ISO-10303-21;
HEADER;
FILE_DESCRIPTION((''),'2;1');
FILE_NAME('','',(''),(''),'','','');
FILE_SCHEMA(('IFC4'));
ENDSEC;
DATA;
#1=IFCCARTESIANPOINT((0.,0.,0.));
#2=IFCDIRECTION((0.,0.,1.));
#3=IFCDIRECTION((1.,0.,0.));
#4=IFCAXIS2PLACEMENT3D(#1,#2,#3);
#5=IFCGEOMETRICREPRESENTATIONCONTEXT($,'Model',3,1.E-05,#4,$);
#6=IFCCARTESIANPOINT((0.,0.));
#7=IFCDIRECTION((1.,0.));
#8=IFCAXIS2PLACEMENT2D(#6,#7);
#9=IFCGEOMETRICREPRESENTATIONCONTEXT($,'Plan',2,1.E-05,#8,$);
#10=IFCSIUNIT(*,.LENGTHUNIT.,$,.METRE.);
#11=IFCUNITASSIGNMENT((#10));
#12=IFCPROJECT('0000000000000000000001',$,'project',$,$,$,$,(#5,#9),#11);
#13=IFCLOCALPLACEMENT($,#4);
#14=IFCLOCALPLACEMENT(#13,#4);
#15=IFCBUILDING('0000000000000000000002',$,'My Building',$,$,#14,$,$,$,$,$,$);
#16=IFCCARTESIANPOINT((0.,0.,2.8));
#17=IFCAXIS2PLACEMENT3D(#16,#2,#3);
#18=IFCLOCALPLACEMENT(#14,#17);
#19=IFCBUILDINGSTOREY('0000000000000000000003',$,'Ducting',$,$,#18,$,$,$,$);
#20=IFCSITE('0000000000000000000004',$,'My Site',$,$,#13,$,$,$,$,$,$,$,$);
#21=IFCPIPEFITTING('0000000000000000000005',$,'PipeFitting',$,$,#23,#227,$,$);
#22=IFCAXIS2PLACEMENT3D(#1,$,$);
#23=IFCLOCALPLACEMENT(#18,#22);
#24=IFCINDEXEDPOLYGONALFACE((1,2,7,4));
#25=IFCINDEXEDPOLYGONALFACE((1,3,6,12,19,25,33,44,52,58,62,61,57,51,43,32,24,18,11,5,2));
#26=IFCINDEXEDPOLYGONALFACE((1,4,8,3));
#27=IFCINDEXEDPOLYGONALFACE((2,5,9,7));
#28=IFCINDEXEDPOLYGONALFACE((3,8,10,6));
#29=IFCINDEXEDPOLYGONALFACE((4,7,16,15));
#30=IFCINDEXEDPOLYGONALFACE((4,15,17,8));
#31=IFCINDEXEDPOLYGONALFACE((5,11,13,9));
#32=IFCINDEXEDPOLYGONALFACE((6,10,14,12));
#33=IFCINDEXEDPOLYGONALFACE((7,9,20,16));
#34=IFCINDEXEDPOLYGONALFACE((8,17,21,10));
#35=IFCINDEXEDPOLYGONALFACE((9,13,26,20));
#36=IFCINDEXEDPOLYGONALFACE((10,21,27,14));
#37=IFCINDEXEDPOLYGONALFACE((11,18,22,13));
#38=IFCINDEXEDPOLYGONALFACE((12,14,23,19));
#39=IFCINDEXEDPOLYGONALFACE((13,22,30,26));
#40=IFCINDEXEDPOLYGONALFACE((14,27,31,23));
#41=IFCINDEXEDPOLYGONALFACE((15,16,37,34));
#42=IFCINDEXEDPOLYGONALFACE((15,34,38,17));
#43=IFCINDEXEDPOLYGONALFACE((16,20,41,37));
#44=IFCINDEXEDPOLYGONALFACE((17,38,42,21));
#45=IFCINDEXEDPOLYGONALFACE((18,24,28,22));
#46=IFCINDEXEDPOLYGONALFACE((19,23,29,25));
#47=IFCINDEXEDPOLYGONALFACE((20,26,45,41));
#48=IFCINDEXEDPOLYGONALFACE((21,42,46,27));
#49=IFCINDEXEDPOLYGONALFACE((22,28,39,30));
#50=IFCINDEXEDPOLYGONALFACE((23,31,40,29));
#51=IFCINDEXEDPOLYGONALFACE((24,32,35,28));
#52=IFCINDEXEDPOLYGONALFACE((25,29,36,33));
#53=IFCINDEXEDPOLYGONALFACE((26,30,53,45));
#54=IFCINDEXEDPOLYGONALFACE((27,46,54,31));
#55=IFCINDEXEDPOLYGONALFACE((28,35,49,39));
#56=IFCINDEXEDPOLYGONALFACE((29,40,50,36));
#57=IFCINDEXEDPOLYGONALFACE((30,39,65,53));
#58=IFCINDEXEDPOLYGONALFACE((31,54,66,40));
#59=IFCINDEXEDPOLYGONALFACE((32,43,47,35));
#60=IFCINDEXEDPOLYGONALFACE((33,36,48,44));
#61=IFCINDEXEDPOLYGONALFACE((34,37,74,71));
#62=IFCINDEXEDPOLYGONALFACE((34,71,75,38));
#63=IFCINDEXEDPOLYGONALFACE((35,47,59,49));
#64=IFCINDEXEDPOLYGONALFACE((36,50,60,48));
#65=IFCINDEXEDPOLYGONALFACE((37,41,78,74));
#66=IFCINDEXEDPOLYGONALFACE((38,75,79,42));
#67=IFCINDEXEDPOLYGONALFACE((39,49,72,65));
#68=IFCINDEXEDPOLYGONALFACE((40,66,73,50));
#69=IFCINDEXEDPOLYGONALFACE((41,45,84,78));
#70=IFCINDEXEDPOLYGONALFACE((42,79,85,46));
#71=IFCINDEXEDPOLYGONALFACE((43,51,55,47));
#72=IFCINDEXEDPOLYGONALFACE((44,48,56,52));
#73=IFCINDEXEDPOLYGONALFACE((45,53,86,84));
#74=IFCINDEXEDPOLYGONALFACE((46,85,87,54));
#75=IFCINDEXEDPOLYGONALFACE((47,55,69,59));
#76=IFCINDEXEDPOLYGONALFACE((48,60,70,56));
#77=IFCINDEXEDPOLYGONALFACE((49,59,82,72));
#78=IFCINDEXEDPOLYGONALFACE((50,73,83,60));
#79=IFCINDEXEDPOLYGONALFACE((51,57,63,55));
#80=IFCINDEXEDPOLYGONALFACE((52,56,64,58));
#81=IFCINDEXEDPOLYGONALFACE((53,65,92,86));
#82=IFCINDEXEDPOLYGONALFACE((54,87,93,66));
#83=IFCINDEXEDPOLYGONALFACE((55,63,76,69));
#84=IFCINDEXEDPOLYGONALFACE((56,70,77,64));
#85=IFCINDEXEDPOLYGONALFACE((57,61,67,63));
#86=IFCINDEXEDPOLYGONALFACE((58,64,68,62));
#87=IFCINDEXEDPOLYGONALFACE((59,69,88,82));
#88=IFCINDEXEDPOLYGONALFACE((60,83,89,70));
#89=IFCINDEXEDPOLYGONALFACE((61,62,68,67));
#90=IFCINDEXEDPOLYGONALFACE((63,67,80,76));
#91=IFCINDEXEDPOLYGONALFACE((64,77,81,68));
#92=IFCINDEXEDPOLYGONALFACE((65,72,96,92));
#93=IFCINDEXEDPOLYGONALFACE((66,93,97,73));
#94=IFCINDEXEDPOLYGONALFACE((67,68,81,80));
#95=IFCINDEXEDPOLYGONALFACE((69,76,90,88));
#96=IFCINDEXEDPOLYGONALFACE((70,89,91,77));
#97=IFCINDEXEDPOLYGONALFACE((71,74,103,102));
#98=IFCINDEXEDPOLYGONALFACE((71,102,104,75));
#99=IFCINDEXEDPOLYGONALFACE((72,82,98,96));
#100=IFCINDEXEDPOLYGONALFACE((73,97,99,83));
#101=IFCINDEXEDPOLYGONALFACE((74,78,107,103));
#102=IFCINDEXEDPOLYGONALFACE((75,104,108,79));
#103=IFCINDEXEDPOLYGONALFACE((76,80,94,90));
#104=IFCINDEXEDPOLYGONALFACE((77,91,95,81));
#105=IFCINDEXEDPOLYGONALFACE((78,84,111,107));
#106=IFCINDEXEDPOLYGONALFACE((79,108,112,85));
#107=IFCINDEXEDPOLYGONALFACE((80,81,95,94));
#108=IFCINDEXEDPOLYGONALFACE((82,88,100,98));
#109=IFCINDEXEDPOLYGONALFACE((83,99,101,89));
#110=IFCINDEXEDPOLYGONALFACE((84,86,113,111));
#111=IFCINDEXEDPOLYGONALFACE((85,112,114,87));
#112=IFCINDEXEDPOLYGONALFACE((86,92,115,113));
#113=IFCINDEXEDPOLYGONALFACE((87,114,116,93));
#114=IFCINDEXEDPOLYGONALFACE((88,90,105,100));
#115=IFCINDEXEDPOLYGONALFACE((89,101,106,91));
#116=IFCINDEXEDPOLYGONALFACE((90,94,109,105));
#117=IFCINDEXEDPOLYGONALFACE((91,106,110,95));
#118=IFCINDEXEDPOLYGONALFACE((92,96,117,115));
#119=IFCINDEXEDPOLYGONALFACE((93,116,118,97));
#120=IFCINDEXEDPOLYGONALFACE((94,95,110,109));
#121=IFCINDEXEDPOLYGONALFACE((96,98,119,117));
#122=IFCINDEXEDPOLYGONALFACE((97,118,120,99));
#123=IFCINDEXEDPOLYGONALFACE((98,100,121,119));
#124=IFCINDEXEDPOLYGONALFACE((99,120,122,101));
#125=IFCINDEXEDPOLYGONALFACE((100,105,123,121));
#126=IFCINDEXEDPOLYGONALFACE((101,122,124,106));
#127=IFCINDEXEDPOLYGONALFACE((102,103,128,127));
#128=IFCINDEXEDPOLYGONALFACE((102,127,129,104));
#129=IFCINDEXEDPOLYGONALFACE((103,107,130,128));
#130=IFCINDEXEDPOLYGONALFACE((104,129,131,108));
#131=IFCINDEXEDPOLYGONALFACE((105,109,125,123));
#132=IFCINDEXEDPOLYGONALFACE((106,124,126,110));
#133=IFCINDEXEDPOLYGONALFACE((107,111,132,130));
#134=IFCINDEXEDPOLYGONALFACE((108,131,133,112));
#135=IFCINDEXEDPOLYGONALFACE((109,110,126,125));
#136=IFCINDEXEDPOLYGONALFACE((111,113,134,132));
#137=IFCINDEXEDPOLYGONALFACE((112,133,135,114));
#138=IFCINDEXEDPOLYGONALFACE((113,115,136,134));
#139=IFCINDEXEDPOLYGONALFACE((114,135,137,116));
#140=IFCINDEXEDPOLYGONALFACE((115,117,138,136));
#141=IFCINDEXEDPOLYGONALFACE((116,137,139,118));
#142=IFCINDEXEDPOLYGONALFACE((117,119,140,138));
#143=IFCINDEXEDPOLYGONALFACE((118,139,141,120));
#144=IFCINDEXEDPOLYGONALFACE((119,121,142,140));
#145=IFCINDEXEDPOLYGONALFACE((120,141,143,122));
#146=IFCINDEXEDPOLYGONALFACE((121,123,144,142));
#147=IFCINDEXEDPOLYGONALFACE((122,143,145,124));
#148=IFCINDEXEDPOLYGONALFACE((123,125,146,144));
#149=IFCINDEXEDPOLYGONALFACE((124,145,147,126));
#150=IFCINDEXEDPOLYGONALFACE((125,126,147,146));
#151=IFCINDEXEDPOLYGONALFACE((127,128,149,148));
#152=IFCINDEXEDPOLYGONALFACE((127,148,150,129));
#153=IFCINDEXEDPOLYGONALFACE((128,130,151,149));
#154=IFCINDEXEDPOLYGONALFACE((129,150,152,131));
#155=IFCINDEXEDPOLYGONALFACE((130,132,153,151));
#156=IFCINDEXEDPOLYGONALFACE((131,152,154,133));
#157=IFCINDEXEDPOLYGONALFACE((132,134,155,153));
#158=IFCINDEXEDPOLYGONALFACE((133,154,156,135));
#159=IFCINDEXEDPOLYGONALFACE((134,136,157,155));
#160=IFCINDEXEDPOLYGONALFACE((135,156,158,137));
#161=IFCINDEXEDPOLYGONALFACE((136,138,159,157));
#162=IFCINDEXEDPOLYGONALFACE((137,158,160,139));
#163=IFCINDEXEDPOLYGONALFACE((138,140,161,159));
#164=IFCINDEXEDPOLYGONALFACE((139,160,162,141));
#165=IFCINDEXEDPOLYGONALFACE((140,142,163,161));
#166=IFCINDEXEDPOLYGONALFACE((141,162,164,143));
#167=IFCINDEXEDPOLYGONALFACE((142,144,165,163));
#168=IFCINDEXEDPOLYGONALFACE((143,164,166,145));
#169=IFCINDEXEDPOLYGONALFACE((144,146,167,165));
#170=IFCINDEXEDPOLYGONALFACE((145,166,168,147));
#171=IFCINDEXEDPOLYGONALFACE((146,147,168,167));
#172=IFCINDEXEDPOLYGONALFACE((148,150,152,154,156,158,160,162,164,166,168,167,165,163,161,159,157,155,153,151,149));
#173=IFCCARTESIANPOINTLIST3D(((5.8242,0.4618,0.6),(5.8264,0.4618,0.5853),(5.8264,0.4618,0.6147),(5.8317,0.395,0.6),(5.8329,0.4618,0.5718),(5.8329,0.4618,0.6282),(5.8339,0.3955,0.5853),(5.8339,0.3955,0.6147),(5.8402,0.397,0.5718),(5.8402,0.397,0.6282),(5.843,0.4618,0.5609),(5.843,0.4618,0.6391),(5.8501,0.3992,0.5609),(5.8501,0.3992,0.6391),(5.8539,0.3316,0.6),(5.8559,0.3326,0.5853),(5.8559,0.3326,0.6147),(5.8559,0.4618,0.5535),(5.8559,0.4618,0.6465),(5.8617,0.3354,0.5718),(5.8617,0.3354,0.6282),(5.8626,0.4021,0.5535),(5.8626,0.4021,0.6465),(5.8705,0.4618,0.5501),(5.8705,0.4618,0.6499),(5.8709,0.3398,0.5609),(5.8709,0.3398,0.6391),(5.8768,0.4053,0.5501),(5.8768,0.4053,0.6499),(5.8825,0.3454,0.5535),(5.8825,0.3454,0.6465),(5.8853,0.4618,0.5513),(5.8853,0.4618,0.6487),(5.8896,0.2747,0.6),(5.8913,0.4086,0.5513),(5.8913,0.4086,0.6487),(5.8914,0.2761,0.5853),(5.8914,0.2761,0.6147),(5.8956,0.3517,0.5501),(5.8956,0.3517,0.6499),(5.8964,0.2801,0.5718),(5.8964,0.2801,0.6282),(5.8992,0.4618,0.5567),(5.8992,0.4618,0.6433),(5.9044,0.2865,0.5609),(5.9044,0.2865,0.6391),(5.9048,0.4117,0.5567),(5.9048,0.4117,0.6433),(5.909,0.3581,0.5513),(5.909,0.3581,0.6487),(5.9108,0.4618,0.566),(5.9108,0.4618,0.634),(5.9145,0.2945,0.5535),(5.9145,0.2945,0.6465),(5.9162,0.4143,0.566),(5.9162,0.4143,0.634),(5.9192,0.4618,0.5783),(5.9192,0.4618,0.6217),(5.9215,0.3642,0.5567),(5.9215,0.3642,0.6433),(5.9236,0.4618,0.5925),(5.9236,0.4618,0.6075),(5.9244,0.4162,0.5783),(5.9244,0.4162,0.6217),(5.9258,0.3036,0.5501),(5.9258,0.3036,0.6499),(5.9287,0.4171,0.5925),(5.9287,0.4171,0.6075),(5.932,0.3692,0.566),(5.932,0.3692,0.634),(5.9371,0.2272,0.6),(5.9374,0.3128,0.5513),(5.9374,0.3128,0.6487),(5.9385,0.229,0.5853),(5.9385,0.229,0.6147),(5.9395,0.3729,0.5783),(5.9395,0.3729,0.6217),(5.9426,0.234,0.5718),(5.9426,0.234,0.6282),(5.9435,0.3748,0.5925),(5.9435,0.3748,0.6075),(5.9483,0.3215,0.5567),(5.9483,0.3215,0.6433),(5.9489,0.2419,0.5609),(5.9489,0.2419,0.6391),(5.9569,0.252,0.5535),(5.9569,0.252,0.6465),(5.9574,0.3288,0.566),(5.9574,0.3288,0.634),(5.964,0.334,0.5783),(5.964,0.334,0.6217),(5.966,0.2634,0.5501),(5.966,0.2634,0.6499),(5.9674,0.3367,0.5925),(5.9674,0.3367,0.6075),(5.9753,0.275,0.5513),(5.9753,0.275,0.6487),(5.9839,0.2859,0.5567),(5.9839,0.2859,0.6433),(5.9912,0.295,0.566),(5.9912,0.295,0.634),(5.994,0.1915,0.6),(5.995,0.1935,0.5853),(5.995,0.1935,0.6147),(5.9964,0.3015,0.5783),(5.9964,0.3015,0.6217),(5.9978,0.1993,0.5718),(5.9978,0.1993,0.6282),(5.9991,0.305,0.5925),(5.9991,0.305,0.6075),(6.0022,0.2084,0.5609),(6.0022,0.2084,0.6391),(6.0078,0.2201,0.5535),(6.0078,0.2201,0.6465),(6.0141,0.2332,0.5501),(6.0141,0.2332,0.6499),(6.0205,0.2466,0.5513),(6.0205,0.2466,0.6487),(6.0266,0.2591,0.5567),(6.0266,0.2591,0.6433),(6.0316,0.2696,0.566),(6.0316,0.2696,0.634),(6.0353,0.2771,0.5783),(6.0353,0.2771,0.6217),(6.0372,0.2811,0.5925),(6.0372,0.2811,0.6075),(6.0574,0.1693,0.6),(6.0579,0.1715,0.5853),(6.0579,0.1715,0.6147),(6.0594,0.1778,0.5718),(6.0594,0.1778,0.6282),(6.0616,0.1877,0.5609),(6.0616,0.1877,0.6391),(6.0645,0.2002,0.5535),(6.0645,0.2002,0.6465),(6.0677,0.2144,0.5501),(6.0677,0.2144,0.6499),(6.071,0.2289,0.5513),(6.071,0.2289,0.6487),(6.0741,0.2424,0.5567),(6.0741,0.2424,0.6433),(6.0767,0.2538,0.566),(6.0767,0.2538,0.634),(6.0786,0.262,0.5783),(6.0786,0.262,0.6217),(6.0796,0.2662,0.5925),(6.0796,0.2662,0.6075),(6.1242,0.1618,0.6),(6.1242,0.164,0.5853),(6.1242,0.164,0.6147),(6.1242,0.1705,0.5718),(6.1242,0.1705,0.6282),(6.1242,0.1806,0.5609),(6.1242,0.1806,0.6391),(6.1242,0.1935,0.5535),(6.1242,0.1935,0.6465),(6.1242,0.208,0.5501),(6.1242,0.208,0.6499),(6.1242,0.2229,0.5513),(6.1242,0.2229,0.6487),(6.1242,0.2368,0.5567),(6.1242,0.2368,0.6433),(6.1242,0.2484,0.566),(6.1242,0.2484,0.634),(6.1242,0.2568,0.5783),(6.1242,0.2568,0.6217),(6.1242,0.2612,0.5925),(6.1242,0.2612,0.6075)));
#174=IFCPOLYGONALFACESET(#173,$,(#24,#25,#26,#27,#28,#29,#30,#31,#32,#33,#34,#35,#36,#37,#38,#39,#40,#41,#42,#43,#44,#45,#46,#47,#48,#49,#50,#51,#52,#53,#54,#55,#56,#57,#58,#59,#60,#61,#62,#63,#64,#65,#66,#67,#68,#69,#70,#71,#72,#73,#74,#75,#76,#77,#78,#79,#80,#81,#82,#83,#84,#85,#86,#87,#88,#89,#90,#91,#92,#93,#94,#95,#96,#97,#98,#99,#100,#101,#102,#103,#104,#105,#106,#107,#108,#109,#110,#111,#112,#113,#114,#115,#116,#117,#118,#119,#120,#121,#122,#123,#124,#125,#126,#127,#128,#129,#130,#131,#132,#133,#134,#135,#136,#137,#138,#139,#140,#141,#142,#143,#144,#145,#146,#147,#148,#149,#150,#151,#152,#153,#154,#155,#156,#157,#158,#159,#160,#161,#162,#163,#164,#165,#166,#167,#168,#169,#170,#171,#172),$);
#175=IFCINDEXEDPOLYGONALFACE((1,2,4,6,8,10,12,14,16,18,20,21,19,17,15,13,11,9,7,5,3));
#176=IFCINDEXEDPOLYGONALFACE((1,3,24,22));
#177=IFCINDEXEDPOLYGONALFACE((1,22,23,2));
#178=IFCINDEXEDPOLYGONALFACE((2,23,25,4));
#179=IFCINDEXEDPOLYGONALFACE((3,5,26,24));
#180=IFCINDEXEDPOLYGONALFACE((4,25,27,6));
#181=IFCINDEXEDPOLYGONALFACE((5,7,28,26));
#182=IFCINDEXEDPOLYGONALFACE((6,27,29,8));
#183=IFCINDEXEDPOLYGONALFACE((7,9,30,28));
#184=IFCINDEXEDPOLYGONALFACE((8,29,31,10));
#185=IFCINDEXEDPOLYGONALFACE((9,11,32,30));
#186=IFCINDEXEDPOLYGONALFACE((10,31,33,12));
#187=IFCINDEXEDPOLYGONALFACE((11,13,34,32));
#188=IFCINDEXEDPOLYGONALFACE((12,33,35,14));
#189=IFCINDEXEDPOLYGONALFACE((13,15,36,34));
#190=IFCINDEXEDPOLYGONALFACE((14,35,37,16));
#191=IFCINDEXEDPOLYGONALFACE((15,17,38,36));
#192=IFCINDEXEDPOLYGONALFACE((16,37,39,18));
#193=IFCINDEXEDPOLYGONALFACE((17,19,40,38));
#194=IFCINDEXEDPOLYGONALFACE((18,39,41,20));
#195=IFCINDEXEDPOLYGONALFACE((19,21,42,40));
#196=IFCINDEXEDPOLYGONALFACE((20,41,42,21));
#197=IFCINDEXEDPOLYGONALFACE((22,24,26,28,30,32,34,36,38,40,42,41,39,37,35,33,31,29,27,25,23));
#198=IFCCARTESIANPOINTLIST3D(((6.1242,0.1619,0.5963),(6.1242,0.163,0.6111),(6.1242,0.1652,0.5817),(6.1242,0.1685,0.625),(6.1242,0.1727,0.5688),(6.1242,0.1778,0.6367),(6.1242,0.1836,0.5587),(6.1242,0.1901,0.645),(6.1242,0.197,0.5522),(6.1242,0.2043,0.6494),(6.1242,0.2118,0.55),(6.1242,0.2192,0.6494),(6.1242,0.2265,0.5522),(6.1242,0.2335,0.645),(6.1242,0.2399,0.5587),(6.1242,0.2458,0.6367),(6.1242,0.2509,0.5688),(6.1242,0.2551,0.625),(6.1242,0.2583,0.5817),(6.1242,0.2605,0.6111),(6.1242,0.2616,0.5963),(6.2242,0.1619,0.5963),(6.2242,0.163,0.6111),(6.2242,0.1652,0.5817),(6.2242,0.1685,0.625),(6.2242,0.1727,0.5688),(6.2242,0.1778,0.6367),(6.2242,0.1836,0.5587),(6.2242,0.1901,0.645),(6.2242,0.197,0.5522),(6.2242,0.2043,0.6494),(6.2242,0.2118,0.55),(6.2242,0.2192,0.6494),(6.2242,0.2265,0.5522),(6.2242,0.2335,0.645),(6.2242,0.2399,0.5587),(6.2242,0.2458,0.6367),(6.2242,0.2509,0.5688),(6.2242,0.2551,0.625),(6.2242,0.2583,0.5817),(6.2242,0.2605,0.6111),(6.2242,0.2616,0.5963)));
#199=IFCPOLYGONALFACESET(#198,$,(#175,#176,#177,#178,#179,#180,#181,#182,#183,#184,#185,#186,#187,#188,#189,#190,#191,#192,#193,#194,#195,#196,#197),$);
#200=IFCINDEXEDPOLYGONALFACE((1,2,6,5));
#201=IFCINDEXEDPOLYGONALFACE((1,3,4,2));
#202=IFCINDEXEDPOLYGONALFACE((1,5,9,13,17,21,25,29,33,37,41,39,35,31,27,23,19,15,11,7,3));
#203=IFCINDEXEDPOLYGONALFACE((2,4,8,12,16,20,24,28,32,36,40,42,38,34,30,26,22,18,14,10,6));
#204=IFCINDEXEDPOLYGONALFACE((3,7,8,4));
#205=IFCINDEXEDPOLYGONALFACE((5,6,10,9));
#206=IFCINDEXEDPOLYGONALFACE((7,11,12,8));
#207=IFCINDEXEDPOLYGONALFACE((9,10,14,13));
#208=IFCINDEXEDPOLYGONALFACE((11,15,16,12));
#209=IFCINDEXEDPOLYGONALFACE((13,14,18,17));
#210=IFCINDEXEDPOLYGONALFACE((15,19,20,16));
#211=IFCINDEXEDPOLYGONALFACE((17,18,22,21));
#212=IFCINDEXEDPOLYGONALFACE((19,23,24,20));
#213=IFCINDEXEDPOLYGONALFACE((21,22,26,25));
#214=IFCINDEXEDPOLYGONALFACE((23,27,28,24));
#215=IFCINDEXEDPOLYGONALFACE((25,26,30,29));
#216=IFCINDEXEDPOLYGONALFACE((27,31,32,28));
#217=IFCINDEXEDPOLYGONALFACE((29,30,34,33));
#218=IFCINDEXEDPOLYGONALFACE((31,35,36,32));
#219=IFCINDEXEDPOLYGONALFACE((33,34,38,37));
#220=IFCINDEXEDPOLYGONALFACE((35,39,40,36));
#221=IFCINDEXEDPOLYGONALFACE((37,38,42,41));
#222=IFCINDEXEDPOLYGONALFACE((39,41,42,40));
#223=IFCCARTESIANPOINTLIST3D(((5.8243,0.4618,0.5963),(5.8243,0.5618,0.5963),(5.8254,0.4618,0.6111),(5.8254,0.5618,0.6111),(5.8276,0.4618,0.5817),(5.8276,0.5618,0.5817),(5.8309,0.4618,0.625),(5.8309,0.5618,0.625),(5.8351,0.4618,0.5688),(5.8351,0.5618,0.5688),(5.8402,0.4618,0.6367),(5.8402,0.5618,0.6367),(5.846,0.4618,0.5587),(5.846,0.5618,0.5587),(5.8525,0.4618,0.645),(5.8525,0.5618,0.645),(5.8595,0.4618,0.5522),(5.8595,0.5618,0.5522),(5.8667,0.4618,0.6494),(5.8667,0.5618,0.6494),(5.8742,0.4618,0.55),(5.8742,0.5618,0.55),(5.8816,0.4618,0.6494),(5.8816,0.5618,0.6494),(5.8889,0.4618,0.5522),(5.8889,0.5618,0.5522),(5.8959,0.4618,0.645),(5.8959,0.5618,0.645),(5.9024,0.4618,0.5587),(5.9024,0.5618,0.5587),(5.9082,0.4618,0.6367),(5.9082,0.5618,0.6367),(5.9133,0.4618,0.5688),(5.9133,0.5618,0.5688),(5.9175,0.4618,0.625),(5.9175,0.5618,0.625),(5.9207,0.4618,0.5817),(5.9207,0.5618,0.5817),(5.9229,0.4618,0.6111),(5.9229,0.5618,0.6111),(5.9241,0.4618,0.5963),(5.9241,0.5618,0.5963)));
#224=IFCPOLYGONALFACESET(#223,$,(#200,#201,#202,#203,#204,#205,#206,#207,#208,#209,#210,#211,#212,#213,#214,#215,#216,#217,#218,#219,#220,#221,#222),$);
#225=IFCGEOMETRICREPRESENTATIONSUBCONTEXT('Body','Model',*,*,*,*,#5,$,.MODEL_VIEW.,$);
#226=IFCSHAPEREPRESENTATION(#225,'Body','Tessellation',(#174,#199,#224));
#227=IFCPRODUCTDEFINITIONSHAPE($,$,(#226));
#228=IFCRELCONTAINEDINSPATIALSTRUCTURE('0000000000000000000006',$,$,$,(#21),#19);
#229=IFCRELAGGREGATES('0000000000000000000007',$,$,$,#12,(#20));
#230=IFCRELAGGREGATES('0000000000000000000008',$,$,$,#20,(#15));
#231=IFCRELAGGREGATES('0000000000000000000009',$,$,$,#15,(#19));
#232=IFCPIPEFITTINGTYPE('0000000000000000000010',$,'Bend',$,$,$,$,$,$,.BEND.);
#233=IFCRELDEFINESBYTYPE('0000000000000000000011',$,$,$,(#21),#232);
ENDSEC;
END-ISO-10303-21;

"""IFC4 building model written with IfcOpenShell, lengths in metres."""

from ifc_helpers import new_model, entity, si_unit, frame, origin_with_axes, origin_2d_with_axis, place, context, subcontext, project, spatial, circle, extrude, source, transform, mapped, type_object, type_shapes, element, save


model = new_model("IFC4")

# Units and contexts
model_context = context("Model", 3, precision=1e-05, world=origin_with_axes())
plan_context = context("Plan", 2, precision=1e-05, world=origin_2d_with_axis())
body_context = subcontext(model_context, "Body", "Model", "MODEL_VIEW")
ifc_project = project(units=[si_unit("LENGTHUNIT", "METRE")], contexts=[model_context, plan_context])

# Site, building, storey
site_placement = place(None, origin_with_axes())
site = spatial("IfcSite", under=ifc_project, at=site_placement, Name="My Site")
building_placement = place(site_placement, origin_with_axes())
building = spatial("IfcBuilding", under=site, at=building_placement, Name="My Building")
storey_placement = place(building_placement, frame((0.0, 0.0, 2.8), z_axis=(0.0, 0.0, 1.0), x_axis=(1.0, 0.0, 0.0)))
storey = spatial("IfcBuildingStorey", under=building, at=storey_placement, Name="Ducting")

# Pipe fitting
pipe_fitting_type = type_object("IfcPipeFittingType", Name="Bend", PredefinedType="BEND")
shared_shape_1 = source(origin_with_axes(), body_context, "Body", "SolidModel", [
    entity("IfcSweptDiskSolid", entity("IfcIndexedPolyCurve", entity("IfcCartesianPointList3D", [[0.0, 0.0, 0.1], [0.0, -0.0732, 0.2768], [0.0, -0.25, 0.35]]), [entity("IfcArcIndex", [1, 2, 3])]), 0.05),
    extrude(circle(Radius=0.05), origin_with_axes(), (0.0, 0.0, 1.0), 0.1),
    extrude(circle(Radius=0.05), frame((0.0, -0.25, 0.35), z_axis=(0.0, -1.0, 0.0), x_axis=(1.0, 0.0, 0.0)), (0.0, 0.0, 1.0), 0.1),
])
type_shapes(pipe_fitting_type, [shared_shape_1])
for number, where, z_axis, x_axis, name in (
    (1, (6.2242, 0.2118, 0.6), (-1.0, 0.0, 0.0), (0.0, 0.0, -1.0), "PipeFitting"),
):
    element("IfcPipeFitting", number, at=place(storey_placement, frame(where, z_axis=z_axis, x_axis=x_axis)), inside=storey, type_object=pipe_fitting_type, Name=name, context=body_context, shape_type="MappedRepresentation", body=[
        mapped(shared_shape_1, transform((0.0, 0.0, 0.0), x_axis=(1.0, 0.0, 0.0), y_axis=(0.0, 1.0, 0.0), z_axis=(0.0, 0.0, 1.0), scale=1.0)),
    ])

save(model, "model.ifc")
